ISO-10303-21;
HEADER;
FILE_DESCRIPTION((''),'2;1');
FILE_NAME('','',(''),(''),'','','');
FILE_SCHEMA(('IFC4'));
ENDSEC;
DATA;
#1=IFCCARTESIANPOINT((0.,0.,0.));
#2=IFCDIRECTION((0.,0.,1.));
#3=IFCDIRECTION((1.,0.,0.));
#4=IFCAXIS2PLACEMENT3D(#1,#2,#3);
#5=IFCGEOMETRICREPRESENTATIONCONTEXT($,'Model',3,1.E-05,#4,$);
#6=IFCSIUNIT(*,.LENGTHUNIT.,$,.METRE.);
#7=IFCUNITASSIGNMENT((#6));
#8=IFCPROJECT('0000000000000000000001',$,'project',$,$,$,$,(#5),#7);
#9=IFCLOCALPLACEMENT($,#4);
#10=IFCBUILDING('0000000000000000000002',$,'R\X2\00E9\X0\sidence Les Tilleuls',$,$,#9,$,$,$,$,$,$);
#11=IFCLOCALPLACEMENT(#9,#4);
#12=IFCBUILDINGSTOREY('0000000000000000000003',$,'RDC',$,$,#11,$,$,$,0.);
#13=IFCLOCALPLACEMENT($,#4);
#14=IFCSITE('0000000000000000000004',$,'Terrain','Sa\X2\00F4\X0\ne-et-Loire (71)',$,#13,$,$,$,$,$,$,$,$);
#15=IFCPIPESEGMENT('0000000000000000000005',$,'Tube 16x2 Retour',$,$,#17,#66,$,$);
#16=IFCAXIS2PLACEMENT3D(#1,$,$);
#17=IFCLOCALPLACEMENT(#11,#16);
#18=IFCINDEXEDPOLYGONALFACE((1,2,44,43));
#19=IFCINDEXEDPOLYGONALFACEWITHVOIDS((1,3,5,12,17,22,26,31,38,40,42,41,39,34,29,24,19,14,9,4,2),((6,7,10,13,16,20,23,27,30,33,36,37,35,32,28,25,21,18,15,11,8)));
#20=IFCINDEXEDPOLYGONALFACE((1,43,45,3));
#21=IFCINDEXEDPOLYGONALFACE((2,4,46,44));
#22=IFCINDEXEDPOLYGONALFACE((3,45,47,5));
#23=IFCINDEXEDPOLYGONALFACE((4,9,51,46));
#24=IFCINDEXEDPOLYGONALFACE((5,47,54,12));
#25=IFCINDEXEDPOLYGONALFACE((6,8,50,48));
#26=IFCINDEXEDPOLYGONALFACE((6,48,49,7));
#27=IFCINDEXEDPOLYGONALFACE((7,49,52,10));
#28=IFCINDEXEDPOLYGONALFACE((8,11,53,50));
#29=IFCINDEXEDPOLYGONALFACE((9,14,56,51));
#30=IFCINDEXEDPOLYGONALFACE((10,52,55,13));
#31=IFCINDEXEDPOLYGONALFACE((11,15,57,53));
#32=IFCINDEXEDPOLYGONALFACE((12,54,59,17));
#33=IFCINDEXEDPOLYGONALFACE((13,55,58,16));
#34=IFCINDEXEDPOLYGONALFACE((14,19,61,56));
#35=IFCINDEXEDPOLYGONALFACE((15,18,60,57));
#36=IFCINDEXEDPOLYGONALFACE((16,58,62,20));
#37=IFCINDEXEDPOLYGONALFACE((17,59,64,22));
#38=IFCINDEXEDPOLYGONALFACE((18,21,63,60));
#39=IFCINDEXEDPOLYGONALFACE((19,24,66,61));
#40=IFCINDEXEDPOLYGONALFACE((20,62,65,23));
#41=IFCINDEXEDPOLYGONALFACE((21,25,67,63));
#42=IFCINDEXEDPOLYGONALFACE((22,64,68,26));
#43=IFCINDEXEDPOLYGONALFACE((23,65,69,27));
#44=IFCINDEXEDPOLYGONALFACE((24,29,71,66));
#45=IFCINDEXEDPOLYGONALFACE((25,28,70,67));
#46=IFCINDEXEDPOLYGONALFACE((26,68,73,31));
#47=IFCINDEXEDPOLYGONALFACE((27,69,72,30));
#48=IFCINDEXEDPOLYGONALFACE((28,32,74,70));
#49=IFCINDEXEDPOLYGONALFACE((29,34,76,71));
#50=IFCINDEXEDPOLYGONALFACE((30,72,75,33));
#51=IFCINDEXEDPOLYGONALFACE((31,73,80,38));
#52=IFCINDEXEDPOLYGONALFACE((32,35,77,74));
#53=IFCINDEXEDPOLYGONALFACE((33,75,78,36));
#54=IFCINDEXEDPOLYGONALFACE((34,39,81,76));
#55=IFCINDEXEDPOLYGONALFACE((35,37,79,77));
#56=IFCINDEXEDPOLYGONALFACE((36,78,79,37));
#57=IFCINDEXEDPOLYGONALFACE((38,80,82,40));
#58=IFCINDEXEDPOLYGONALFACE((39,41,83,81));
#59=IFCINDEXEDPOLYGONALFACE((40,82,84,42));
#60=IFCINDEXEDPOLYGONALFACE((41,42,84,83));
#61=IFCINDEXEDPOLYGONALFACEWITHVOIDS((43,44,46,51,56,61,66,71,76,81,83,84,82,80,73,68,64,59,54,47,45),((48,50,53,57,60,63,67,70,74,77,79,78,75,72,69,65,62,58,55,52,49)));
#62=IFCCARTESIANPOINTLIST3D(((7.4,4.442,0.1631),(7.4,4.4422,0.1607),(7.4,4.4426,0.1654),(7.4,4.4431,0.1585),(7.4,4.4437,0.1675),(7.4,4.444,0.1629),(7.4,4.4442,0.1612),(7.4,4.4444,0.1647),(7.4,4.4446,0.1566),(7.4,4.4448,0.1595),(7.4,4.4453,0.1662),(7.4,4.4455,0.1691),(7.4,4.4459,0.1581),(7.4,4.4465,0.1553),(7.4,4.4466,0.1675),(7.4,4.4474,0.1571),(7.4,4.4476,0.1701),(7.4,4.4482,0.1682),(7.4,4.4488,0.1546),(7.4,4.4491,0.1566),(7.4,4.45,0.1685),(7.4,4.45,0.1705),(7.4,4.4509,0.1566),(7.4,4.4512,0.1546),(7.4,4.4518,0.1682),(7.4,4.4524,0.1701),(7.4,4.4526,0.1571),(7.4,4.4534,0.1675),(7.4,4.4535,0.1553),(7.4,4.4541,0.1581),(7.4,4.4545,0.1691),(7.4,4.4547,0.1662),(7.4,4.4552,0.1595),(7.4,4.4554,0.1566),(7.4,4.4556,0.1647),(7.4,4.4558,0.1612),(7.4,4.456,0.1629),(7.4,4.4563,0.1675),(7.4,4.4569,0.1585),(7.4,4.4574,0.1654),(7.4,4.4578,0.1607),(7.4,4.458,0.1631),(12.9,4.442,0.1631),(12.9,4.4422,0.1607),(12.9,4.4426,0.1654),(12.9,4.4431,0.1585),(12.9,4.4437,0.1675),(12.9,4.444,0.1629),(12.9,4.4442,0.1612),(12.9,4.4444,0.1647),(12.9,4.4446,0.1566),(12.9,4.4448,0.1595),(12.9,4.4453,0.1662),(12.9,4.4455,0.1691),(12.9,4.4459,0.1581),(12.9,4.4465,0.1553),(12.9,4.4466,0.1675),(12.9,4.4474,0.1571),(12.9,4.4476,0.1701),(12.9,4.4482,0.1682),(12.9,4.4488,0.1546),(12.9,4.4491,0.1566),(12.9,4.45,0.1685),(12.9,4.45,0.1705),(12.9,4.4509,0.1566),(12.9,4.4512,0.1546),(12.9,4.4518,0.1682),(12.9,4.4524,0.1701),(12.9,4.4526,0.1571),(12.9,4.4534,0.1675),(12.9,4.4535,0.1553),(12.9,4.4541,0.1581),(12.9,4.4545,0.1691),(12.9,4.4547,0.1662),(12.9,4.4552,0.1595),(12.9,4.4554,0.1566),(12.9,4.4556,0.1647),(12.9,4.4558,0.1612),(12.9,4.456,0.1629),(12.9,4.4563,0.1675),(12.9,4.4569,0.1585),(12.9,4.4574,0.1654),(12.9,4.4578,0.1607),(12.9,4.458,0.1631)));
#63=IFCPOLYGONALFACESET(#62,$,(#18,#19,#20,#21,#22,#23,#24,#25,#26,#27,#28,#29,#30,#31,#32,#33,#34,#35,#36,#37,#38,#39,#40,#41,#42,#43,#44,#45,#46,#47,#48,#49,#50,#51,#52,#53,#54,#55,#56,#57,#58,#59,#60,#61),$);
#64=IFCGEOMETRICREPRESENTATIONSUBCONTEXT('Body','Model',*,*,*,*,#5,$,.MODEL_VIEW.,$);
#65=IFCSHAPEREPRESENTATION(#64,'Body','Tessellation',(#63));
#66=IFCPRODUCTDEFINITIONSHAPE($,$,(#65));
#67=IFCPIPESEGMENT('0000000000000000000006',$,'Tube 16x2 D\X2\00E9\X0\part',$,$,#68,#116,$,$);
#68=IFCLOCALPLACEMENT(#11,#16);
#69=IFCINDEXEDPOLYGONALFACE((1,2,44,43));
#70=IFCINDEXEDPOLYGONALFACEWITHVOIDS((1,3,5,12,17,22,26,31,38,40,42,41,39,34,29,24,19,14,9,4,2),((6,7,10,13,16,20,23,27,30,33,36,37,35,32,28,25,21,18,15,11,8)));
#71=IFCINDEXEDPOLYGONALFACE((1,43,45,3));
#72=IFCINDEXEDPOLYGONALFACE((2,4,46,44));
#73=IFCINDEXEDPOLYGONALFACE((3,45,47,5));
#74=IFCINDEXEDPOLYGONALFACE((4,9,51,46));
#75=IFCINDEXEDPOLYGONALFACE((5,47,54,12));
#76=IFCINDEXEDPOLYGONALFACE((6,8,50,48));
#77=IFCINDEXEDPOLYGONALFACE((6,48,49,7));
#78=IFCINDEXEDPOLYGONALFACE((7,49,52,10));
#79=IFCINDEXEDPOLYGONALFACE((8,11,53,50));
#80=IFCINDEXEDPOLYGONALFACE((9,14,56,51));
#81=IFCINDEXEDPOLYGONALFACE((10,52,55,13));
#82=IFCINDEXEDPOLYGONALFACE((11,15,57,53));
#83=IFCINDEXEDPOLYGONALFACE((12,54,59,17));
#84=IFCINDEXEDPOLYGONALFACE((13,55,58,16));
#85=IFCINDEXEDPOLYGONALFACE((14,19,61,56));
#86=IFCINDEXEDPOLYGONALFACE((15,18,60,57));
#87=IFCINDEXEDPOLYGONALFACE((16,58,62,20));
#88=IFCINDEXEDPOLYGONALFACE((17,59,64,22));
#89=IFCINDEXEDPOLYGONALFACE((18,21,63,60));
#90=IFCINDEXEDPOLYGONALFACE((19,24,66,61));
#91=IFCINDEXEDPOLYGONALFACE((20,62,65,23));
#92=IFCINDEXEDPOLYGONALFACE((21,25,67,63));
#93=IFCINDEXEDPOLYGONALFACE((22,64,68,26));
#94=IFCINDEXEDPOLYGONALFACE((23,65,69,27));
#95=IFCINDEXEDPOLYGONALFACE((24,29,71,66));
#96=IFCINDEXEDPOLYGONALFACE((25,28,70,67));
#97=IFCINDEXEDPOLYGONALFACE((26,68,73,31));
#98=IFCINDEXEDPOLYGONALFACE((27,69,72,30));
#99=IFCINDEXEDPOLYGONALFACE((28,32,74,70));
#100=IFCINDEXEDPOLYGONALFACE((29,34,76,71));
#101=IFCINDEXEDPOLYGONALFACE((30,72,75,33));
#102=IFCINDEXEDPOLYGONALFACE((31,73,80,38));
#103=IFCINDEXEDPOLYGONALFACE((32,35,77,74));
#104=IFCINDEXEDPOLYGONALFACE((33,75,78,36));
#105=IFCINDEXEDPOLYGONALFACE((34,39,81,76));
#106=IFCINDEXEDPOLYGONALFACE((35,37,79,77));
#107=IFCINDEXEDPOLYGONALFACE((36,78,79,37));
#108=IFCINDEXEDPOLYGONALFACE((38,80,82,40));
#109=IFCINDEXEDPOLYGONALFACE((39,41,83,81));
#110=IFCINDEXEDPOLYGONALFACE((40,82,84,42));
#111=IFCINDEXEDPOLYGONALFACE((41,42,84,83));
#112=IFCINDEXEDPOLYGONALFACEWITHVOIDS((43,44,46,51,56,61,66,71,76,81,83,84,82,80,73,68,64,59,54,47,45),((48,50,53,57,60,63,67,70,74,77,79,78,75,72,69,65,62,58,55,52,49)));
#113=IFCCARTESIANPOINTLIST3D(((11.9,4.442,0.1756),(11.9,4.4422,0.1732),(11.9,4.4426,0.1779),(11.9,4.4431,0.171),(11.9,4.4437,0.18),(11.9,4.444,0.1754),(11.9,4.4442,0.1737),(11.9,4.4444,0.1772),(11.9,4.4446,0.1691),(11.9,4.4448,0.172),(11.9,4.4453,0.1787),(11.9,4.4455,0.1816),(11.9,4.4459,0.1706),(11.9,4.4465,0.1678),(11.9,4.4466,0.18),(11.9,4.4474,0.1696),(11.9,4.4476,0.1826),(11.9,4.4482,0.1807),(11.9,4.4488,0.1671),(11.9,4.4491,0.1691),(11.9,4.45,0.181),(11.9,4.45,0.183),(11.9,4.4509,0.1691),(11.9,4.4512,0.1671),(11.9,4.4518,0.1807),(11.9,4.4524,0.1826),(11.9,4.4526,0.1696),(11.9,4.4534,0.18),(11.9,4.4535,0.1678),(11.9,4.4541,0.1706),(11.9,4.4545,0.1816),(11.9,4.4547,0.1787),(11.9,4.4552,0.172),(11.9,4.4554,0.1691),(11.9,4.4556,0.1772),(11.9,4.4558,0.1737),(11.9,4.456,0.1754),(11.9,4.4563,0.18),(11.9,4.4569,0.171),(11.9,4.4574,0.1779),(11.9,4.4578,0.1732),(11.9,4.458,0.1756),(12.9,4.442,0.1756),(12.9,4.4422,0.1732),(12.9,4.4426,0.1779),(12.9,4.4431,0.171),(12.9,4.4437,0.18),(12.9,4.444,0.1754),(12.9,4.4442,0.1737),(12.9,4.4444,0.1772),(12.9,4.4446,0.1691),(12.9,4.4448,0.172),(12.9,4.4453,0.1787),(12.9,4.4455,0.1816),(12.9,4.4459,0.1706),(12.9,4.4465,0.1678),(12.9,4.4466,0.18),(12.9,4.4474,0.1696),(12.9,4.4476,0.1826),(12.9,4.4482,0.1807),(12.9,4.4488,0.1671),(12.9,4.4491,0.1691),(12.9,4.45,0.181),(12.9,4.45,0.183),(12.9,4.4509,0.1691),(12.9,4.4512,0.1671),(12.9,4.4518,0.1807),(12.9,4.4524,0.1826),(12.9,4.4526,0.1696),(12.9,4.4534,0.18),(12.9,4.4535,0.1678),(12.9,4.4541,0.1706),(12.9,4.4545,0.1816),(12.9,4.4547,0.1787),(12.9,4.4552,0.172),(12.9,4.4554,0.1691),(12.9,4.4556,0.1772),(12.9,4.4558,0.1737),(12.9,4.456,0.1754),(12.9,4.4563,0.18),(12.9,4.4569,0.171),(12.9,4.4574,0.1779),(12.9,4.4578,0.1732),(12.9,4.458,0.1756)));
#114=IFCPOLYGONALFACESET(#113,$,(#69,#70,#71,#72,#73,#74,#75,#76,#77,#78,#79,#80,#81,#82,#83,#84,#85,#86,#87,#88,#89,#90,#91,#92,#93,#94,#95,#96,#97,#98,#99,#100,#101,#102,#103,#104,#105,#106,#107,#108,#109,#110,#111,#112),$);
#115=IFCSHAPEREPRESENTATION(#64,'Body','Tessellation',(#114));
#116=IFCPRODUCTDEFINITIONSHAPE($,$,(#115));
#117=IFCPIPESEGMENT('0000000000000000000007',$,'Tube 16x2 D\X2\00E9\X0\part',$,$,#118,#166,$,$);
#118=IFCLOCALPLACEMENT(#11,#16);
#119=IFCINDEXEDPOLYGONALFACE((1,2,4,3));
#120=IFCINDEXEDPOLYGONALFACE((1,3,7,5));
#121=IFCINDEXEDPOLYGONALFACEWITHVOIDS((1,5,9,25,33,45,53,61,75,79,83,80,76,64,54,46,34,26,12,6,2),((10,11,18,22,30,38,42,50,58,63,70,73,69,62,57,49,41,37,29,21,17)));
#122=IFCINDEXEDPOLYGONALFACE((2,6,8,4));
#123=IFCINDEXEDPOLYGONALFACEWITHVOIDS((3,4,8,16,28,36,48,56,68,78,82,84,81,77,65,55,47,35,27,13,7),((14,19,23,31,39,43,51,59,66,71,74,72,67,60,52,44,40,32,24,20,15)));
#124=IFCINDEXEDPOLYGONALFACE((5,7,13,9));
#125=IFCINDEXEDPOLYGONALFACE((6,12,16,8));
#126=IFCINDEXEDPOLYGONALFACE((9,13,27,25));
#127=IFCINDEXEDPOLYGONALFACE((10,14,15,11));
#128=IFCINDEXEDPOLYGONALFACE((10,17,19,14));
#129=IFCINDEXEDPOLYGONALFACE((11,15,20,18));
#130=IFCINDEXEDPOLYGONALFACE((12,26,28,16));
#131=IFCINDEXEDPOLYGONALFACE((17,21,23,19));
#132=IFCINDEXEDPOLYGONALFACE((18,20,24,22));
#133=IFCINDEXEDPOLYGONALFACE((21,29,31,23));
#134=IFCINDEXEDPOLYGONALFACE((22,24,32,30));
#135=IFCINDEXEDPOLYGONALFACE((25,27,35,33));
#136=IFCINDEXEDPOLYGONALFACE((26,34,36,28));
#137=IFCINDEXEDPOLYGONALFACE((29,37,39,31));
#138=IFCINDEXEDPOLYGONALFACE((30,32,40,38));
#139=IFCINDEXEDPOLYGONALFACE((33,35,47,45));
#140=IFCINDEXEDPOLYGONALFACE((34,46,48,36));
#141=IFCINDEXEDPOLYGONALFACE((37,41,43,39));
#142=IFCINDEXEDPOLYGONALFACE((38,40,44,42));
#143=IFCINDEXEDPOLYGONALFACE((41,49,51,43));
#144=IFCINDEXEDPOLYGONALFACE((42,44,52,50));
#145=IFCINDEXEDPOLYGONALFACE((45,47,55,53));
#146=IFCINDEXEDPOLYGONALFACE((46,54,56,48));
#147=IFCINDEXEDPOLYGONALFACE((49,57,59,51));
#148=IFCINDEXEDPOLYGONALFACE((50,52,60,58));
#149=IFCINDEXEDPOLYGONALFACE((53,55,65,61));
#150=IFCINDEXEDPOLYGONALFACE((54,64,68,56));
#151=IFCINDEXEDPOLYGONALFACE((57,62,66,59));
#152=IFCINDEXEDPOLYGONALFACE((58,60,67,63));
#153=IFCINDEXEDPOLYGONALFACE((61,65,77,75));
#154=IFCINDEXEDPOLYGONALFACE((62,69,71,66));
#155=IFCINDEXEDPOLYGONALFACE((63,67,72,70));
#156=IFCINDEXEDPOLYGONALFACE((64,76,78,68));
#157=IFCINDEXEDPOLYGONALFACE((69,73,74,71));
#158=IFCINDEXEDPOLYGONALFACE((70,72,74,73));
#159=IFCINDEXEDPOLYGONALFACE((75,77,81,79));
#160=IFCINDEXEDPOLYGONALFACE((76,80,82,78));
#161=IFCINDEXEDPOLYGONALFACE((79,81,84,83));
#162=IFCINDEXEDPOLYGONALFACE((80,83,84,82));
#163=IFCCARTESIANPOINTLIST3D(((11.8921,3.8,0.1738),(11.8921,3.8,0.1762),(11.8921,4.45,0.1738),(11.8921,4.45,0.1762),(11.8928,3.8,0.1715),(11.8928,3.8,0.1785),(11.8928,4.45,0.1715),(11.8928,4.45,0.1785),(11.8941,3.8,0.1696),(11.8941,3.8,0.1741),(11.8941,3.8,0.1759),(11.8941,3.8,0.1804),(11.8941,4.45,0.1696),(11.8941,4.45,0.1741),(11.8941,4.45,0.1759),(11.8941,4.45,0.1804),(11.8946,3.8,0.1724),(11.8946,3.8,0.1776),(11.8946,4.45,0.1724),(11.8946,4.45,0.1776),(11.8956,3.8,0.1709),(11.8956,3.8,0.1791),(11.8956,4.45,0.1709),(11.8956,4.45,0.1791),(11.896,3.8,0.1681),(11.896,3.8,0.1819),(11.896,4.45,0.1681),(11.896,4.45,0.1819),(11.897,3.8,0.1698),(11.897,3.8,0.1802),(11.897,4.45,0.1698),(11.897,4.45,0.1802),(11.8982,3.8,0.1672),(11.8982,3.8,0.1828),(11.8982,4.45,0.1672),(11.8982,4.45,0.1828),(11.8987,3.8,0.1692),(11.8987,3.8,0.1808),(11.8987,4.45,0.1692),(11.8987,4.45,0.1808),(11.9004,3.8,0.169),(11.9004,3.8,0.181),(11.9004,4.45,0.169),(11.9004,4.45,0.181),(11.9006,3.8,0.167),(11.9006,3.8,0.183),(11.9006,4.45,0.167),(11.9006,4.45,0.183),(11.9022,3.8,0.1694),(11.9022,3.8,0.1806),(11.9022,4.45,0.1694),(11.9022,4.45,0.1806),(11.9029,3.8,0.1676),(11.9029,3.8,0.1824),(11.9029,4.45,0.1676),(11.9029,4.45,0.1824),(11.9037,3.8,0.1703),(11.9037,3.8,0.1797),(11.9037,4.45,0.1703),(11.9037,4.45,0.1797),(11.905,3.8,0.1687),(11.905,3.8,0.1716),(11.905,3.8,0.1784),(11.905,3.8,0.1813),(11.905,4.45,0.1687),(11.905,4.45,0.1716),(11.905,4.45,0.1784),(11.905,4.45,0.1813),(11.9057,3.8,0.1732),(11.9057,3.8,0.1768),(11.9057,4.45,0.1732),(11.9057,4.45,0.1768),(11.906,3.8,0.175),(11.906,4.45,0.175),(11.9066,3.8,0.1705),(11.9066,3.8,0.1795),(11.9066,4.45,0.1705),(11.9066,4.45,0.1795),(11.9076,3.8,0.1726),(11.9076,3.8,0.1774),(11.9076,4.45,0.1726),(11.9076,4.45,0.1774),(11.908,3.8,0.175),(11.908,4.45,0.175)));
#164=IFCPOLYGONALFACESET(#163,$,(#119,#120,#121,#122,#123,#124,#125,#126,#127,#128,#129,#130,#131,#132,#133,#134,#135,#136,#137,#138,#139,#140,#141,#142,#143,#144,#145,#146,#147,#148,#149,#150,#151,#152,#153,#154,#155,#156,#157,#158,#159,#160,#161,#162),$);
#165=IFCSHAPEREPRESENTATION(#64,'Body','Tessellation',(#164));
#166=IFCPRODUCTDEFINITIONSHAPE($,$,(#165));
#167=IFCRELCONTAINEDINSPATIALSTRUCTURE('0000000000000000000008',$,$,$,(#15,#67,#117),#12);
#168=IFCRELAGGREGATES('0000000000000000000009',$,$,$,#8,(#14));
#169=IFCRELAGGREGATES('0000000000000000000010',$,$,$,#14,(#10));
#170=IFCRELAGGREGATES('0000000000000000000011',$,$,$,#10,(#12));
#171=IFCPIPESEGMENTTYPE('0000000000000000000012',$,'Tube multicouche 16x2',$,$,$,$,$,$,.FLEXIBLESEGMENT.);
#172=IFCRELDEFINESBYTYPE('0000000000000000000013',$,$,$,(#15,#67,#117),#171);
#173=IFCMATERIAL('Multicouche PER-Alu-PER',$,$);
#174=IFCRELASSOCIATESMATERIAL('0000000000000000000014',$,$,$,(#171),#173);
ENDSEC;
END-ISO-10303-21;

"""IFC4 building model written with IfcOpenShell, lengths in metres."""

from ifc_helpers import new_model, si_unit, frame, origin_with_axes, place, context, subcontext, project, spatial, hollow_circle, extrude, material, type_object, element, save


model = new_model("IFC4")

# Units and contexts
model_context = context("Model", 3, precision=1e-05, world=origin_with_axes())
body_context = subcontext(model_context, "Body", "Model", "MODEL_VIEW")
ifc_project = project(units=[si_unit("LENGTHUNIT", "METRE")], contexts=[model_context])

# Site, building, storey
site_placement = place(None, origin_with_axes())
site = spatial("IfcSite", under=ifc_project, at=site_placement, Name="Terrain", Description="Saône-et-Loire (71)")
building_placement = place(None, origin_with_axes())
building = spatial("IfcBuilding", under=site, at=building_placement, Name="Résidence Les Tilleuls")
storey_placement = place(building_placement, origin_with_axes())
storey = spatial("IfcBuildingStorey", under=building, at=storey_placement, Name="RDC", Elevation=0.0)

# Pipe segments
ifc_material = material(Name="Multicouche PER-Alu-PER")
pipe_segment_type_1 = type_object("IfcPipeSegmentType", Name="Tube multicouche 16x2", PredefinedType="FLEXIBLESEGMENT", material=ifc_material)
pipe_segment_1_placement = place(storey_placement, frame((12.9, 4.45, 0.1625), z_axis=(-1.0, 0.0, 0.0), x_axis=(0.0, 0.0, 1.0)))
element("IfcPipeSegment", 1, at=pipe_segment_1_placement, inside=storey, type_object=pipe_segment_type_1, Name="Tube 16x2 Retour", context=body_context, shape_type="SweptSolid", body=[
    extrude(hollow_circle(Radius=0.008, WallThickness=0.002), origin_with_axes(), (0.0, 0.0, 1.0), 5.5),
])
pipe_segment_2_placement = place(storey_placement, frame((12.9, 4.45, 0.175), z_axis=(-1.0, 0.0, 0.0), x_axis=(0.0, 0.0, 1.0)))
element("IfcPipeSegment", 2, at=pipe_segment_2_placement, inside=storey, type_object=pipe_segment_type_1, Name="Tube 16x2 Départ", context=body_context, shape_type="SweptSolid", body=[
    extrude(hollow_circle(Radius=0.008, WallThickness=0.002), origin_with_axes(), (0.0, 0.0, 1.0), 1.0),
])
pipe_segment_3_placement = place(storey_placement, frame((11.9, 4.45, 0.175), z_axis=(0.0, -1.0, 0.0), x_axis=(1.0, 0.0, 0.0)))
element("IfcPipeSegment", 3, at=pipe_segment_3_placement, inside=storey, type_object=pipe_segment_type_1, Name="Tube 16x2 Départ", context=body_context, shape_type="SweptSolid", body=[
    extrude(hollow_circle(Radius=0.008, WallThickness=0.002), origin_with_axes(), (0.0, 0.0, 1.0), 0.65),
])

save(model, "model.ifc")
